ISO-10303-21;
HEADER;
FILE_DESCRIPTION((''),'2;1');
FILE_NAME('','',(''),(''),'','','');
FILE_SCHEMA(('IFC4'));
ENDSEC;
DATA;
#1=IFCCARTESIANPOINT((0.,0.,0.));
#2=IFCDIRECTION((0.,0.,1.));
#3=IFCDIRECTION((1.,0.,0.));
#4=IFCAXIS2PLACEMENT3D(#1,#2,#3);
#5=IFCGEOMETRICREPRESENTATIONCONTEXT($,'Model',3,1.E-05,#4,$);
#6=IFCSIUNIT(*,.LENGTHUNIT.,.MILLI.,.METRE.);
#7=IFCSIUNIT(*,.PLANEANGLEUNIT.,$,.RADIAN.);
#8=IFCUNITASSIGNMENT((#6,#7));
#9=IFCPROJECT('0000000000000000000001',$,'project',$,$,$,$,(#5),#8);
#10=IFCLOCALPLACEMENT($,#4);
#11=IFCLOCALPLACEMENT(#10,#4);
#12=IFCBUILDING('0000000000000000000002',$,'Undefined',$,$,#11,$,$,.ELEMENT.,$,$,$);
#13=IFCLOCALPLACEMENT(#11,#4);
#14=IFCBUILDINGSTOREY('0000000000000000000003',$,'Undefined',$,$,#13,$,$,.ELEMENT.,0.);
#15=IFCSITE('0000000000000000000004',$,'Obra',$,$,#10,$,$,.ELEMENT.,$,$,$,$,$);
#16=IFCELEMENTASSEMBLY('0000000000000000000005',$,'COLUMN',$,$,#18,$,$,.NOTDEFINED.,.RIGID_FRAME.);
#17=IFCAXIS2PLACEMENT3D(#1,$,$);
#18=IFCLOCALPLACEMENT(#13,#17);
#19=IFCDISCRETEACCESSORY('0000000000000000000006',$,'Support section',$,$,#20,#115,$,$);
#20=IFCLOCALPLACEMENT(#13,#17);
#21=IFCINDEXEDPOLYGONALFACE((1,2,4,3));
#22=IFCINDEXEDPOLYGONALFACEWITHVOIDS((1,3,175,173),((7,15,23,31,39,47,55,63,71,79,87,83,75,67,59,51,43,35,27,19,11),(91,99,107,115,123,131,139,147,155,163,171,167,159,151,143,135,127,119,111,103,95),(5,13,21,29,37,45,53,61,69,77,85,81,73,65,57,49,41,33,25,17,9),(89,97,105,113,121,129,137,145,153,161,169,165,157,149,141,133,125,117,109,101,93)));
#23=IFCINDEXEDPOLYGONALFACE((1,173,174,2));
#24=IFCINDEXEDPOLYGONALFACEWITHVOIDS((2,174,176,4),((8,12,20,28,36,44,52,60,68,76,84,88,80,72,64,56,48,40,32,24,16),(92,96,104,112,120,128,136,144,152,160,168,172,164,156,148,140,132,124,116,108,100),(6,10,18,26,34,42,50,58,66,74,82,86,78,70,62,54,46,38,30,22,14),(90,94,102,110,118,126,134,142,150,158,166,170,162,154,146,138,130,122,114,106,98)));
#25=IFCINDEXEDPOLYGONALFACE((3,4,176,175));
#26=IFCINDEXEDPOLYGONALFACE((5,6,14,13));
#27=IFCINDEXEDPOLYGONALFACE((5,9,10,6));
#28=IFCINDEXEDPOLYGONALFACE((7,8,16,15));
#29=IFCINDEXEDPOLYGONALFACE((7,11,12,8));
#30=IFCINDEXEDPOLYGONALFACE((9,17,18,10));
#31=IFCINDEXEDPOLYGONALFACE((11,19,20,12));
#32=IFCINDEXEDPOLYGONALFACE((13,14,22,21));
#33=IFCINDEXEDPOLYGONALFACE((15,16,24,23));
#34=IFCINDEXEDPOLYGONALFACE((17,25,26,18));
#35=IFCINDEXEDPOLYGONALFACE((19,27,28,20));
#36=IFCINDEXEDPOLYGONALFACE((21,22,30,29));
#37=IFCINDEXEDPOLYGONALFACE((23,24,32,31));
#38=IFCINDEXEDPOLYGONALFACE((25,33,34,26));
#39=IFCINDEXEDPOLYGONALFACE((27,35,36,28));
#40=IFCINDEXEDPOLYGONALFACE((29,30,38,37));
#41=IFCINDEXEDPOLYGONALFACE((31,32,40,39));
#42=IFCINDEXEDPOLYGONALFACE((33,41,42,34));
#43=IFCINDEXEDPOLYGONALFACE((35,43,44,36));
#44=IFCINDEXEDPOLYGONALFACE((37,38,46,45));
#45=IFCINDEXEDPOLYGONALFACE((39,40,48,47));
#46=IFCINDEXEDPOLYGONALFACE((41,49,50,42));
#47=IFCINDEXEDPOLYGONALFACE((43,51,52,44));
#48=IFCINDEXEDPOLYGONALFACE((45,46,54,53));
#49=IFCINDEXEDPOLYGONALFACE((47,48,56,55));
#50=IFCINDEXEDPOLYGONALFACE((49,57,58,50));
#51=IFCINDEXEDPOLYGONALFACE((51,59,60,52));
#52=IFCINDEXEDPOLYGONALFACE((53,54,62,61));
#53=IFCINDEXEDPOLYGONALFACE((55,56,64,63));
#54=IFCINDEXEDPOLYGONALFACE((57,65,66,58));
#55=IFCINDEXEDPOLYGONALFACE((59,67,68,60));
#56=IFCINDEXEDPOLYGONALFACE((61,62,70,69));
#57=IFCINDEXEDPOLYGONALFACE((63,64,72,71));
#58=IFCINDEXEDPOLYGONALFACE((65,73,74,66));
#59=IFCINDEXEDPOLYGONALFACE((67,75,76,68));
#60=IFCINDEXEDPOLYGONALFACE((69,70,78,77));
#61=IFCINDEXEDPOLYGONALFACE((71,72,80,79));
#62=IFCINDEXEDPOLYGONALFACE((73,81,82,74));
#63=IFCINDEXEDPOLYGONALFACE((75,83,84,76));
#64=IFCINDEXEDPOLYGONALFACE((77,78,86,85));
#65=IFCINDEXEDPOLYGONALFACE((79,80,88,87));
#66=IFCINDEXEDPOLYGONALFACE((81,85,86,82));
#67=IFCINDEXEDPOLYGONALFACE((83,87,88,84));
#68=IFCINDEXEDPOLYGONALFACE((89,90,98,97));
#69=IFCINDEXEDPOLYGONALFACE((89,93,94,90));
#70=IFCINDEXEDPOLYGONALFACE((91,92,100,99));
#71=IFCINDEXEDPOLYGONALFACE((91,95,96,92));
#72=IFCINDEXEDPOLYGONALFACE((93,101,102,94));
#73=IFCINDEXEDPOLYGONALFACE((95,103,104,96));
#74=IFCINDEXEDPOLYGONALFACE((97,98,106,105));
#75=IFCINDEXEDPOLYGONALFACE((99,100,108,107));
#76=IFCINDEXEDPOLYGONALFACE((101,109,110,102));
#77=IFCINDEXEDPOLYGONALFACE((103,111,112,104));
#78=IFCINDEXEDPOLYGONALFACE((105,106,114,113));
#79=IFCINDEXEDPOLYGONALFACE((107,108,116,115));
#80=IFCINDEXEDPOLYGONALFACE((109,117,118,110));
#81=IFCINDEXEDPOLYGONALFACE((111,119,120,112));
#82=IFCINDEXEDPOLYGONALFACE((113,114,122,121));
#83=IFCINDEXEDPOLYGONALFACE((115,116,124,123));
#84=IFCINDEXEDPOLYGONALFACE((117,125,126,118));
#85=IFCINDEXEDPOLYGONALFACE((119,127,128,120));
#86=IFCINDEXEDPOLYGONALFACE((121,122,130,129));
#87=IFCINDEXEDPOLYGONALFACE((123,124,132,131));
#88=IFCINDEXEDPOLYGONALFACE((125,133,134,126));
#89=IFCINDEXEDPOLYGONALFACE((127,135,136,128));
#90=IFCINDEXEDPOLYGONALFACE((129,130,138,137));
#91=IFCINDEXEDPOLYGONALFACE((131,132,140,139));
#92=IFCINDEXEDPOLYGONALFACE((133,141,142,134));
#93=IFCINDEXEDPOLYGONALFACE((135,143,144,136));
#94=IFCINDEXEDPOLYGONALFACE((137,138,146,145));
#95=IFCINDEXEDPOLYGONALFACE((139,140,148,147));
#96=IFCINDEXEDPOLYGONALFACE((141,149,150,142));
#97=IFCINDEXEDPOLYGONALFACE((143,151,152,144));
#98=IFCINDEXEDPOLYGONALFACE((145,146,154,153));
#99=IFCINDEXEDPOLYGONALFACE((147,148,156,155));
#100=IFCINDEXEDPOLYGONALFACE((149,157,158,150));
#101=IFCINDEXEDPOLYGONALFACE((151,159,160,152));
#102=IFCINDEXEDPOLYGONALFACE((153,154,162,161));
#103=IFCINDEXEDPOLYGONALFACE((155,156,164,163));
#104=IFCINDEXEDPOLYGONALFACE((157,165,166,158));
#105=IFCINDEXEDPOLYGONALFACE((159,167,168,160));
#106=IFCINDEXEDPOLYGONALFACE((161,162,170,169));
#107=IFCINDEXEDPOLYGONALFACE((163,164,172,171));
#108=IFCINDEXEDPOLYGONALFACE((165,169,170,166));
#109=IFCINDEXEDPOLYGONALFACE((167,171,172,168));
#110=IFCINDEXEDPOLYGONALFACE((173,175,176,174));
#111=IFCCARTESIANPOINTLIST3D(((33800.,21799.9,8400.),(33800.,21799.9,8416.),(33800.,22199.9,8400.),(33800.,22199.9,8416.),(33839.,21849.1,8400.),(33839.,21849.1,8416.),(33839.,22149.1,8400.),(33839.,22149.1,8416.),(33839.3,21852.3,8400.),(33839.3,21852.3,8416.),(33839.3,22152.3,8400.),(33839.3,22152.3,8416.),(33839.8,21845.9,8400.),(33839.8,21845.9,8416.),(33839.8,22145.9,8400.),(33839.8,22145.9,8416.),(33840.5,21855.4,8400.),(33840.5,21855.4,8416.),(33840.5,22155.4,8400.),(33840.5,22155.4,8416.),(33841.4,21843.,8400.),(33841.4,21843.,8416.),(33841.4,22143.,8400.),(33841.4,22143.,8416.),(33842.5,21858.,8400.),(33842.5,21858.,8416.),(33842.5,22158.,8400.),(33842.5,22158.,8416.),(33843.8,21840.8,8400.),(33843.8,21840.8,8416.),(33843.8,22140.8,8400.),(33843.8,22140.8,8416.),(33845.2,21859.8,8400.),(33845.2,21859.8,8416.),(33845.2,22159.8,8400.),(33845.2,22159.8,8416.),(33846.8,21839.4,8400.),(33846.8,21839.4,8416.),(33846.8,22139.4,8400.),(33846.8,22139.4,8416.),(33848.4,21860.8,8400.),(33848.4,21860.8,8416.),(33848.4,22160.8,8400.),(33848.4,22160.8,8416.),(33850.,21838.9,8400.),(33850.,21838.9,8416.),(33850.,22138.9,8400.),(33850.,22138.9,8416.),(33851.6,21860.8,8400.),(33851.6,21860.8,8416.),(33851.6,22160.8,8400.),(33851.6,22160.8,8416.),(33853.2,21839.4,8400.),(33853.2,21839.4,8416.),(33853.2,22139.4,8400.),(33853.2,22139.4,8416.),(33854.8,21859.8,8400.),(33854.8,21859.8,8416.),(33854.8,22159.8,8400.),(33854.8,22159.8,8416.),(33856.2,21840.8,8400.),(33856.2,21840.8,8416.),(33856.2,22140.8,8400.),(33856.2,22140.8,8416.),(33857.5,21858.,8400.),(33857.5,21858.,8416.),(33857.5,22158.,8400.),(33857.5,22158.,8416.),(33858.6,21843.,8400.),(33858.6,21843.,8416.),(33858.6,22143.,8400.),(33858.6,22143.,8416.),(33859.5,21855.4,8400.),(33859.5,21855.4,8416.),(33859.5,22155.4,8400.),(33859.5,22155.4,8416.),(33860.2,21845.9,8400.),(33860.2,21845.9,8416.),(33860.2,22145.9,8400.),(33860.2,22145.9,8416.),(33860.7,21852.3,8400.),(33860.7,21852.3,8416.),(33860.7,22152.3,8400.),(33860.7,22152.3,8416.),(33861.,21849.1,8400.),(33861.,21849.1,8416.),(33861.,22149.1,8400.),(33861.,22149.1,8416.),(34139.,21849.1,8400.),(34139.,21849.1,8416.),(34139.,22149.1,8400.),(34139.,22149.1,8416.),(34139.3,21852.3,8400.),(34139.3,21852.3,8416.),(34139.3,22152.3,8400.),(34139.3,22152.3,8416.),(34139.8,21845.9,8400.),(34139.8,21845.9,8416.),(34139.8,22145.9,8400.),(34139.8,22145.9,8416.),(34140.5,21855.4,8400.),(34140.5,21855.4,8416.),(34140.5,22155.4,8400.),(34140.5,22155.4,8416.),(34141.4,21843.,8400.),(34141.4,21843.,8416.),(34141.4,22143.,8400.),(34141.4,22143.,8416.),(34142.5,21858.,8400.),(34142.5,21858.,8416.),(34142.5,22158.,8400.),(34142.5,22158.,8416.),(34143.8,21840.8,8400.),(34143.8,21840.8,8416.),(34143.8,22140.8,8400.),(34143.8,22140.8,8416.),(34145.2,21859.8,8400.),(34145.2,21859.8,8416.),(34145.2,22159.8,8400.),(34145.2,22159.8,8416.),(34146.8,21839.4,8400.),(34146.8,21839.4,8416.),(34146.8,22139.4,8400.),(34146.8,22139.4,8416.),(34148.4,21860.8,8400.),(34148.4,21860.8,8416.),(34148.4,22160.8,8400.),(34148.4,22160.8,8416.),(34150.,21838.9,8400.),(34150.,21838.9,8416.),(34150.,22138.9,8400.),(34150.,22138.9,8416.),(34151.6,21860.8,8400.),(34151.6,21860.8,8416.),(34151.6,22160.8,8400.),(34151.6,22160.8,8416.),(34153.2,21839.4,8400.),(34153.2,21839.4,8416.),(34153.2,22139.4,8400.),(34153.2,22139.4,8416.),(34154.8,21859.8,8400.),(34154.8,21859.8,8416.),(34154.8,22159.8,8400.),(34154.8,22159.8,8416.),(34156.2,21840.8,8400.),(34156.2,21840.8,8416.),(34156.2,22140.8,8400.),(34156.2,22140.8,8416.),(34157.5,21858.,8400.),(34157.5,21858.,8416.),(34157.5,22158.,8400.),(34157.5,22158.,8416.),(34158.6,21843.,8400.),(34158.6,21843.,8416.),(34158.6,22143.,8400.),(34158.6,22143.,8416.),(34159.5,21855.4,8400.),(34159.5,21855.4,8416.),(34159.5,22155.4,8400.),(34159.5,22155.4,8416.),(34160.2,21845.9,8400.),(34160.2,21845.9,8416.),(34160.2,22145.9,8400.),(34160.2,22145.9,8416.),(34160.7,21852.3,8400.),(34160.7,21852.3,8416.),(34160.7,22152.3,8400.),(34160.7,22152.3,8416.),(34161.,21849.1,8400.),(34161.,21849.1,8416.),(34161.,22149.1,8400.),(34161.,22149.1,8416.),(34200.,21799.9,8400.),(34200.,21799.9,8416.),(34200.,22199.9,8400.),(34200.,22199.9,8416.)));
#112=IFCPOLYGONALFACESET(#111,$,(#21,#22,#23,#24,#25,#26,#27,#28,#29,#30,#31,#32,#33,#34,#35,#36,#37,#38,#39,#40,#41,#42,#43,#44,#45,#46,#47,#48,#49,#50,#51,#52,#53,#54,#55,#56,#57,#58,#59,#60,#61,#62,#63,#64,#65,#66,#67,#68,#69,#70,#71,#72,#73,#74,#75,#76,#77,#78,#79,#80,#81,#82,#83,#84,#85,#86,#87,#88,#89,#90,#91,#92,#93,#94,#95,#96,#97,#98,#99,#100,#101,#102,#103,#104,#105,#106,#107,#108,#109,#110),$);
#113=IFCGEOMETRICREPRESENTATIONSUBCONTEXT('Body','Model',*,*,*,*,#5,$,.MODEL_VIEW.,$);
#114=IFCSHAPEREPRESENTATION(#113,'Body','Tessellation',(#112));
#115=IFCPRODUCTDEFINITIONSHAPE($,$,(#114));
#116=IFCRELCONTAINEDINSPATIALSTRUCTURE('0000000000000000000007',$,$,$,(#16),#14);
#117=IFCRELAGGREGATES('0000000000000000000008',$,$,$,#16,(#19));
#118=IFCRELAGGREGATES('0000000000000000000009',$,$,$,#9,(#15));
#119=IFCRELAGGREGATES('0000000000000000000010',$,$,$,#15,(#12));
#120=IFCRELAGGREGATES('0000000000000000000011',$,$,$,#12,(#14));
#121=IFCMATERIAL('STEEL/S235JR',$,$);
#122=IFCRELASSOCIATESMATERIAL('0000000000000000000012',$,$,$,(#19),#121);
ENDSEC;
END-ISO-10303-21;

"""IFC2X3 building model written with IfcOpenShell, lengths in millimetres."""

from ifc_helpers import new_model, si_unit, frame, origin_with_axes, origin_2d_with_axis, place, context, subcontext, project, spatial, rectangle, circle, extrude, source, transform, mapped, material, element, aggregate, save


model = new_model("IFC2X3")

# Units and contexts
model_context = context("Model", 3, precision=1e-05, world=origin_with_axes())
body_context = subcontext(model_context, "Body", "Model", "MODEL_VIEW")
ifc_project = project(units=[si_unit("LENGTHUNIT", "METRE", prefix="MILLI"), si_unit("PLANEANGLEUNIT", "RADIAN")], contexts=[model_context])

# Site, building, storey
site_placement = place(None, origin_with_axes())
site = spatial("IfcSite", under=ifc_project, at=site_placement, Name="Obra", CompositionType="ELEMENT")
building_placement = place(site_placement, origin_with_axes())
building = spatial("IfcBuilding", under=site, at=building_placement, Name="Undefined", CompositionType="ELEMENT")
storey_placement = place(building_placement, origin_with_axes())
storey = spatial("IfcBuildingStorey", under=building, at=storey_placement, Name="Undefined", CompositionType="ELEMENT", Elevation=0.0)

# Element assembly
assembly_1_placement = place(storey_placement, origin_with_axes())
assembly_1 = element("IfcElementAssembly", 1, at=assembly_1_placement, inside=storey, Name="COLUMN", AssemblyPlace="NOTDEFINED", PredefinedType="RIGID_FRAME")
ifc_material_1 = material(Name="STEEL/S235JR")

# Discrete accessory, opening
discrete_accessory_1_placement = place(assembly_1_placement, frame((34000.0, 21799.9, 8408.0), z_axis=(-1.0, 0.0, 0.0), x_axis=(0.0, 1.0, 0.0)))
discrete_accessory_1 = element("IfcDiscreteAccessory", 2, at=discrete_accessory_1_placement, material=ifc_material_1, Name="Support section", context=body_context, shape_type="SweptSolid", body=[
    extrude(rectangle(XDim=16.0, YDim=400.0, at=origin_2d_with_axis()), frame((400.0, 0.0, 0.0), z_axis=(-1.0, 0.0, 0.0), x_axis=(0.0, -1.0, 0.0)), (0.0, 0.0, 1.0), 400.0),
])
shared_shape_1 = source(origin_with_axes(), body_context, "Body", "SweptSolid", [
    extrude(circle(Radius=11.0, at=origin_2d_with_axis()), frame((0.0, -0.1, 0.0), z_axis=(0.0, 1.0, 0.0), x_axis=(1.0, 0.0, 0.0)), (0.0, 0.0, 1.0), 16.2),
])
opening_1_placement = place(assembly_1_placement, frame((34000.0, 22152.4, 8416.0), z_axis=(1.0, 0.0, 0.0), x_axis=(0.0, -1.0, 0.0)))
element("IfcOpeningElement", 3, at=opening_1_placement, cuts=discrete_accessory_1, ObjectType="Opening", context=body_context, shape_type="MappedRepresentation", body=[
    mapped(shared_shape_1, transform((2.5, 0.0, 150.0))),
    mapped(shared_shape_1, transform((2.5, 0.0, -150.0))),
    mapped(shared_shape_1, transform((302.5, 0.0, 150.0))),
    mapped(shared_shape_1, transform((302.5, 0.0, -150.0))),
])
aggregate(assembly_1, [discrete_accessory_1])

save(model, "model.ifc")
